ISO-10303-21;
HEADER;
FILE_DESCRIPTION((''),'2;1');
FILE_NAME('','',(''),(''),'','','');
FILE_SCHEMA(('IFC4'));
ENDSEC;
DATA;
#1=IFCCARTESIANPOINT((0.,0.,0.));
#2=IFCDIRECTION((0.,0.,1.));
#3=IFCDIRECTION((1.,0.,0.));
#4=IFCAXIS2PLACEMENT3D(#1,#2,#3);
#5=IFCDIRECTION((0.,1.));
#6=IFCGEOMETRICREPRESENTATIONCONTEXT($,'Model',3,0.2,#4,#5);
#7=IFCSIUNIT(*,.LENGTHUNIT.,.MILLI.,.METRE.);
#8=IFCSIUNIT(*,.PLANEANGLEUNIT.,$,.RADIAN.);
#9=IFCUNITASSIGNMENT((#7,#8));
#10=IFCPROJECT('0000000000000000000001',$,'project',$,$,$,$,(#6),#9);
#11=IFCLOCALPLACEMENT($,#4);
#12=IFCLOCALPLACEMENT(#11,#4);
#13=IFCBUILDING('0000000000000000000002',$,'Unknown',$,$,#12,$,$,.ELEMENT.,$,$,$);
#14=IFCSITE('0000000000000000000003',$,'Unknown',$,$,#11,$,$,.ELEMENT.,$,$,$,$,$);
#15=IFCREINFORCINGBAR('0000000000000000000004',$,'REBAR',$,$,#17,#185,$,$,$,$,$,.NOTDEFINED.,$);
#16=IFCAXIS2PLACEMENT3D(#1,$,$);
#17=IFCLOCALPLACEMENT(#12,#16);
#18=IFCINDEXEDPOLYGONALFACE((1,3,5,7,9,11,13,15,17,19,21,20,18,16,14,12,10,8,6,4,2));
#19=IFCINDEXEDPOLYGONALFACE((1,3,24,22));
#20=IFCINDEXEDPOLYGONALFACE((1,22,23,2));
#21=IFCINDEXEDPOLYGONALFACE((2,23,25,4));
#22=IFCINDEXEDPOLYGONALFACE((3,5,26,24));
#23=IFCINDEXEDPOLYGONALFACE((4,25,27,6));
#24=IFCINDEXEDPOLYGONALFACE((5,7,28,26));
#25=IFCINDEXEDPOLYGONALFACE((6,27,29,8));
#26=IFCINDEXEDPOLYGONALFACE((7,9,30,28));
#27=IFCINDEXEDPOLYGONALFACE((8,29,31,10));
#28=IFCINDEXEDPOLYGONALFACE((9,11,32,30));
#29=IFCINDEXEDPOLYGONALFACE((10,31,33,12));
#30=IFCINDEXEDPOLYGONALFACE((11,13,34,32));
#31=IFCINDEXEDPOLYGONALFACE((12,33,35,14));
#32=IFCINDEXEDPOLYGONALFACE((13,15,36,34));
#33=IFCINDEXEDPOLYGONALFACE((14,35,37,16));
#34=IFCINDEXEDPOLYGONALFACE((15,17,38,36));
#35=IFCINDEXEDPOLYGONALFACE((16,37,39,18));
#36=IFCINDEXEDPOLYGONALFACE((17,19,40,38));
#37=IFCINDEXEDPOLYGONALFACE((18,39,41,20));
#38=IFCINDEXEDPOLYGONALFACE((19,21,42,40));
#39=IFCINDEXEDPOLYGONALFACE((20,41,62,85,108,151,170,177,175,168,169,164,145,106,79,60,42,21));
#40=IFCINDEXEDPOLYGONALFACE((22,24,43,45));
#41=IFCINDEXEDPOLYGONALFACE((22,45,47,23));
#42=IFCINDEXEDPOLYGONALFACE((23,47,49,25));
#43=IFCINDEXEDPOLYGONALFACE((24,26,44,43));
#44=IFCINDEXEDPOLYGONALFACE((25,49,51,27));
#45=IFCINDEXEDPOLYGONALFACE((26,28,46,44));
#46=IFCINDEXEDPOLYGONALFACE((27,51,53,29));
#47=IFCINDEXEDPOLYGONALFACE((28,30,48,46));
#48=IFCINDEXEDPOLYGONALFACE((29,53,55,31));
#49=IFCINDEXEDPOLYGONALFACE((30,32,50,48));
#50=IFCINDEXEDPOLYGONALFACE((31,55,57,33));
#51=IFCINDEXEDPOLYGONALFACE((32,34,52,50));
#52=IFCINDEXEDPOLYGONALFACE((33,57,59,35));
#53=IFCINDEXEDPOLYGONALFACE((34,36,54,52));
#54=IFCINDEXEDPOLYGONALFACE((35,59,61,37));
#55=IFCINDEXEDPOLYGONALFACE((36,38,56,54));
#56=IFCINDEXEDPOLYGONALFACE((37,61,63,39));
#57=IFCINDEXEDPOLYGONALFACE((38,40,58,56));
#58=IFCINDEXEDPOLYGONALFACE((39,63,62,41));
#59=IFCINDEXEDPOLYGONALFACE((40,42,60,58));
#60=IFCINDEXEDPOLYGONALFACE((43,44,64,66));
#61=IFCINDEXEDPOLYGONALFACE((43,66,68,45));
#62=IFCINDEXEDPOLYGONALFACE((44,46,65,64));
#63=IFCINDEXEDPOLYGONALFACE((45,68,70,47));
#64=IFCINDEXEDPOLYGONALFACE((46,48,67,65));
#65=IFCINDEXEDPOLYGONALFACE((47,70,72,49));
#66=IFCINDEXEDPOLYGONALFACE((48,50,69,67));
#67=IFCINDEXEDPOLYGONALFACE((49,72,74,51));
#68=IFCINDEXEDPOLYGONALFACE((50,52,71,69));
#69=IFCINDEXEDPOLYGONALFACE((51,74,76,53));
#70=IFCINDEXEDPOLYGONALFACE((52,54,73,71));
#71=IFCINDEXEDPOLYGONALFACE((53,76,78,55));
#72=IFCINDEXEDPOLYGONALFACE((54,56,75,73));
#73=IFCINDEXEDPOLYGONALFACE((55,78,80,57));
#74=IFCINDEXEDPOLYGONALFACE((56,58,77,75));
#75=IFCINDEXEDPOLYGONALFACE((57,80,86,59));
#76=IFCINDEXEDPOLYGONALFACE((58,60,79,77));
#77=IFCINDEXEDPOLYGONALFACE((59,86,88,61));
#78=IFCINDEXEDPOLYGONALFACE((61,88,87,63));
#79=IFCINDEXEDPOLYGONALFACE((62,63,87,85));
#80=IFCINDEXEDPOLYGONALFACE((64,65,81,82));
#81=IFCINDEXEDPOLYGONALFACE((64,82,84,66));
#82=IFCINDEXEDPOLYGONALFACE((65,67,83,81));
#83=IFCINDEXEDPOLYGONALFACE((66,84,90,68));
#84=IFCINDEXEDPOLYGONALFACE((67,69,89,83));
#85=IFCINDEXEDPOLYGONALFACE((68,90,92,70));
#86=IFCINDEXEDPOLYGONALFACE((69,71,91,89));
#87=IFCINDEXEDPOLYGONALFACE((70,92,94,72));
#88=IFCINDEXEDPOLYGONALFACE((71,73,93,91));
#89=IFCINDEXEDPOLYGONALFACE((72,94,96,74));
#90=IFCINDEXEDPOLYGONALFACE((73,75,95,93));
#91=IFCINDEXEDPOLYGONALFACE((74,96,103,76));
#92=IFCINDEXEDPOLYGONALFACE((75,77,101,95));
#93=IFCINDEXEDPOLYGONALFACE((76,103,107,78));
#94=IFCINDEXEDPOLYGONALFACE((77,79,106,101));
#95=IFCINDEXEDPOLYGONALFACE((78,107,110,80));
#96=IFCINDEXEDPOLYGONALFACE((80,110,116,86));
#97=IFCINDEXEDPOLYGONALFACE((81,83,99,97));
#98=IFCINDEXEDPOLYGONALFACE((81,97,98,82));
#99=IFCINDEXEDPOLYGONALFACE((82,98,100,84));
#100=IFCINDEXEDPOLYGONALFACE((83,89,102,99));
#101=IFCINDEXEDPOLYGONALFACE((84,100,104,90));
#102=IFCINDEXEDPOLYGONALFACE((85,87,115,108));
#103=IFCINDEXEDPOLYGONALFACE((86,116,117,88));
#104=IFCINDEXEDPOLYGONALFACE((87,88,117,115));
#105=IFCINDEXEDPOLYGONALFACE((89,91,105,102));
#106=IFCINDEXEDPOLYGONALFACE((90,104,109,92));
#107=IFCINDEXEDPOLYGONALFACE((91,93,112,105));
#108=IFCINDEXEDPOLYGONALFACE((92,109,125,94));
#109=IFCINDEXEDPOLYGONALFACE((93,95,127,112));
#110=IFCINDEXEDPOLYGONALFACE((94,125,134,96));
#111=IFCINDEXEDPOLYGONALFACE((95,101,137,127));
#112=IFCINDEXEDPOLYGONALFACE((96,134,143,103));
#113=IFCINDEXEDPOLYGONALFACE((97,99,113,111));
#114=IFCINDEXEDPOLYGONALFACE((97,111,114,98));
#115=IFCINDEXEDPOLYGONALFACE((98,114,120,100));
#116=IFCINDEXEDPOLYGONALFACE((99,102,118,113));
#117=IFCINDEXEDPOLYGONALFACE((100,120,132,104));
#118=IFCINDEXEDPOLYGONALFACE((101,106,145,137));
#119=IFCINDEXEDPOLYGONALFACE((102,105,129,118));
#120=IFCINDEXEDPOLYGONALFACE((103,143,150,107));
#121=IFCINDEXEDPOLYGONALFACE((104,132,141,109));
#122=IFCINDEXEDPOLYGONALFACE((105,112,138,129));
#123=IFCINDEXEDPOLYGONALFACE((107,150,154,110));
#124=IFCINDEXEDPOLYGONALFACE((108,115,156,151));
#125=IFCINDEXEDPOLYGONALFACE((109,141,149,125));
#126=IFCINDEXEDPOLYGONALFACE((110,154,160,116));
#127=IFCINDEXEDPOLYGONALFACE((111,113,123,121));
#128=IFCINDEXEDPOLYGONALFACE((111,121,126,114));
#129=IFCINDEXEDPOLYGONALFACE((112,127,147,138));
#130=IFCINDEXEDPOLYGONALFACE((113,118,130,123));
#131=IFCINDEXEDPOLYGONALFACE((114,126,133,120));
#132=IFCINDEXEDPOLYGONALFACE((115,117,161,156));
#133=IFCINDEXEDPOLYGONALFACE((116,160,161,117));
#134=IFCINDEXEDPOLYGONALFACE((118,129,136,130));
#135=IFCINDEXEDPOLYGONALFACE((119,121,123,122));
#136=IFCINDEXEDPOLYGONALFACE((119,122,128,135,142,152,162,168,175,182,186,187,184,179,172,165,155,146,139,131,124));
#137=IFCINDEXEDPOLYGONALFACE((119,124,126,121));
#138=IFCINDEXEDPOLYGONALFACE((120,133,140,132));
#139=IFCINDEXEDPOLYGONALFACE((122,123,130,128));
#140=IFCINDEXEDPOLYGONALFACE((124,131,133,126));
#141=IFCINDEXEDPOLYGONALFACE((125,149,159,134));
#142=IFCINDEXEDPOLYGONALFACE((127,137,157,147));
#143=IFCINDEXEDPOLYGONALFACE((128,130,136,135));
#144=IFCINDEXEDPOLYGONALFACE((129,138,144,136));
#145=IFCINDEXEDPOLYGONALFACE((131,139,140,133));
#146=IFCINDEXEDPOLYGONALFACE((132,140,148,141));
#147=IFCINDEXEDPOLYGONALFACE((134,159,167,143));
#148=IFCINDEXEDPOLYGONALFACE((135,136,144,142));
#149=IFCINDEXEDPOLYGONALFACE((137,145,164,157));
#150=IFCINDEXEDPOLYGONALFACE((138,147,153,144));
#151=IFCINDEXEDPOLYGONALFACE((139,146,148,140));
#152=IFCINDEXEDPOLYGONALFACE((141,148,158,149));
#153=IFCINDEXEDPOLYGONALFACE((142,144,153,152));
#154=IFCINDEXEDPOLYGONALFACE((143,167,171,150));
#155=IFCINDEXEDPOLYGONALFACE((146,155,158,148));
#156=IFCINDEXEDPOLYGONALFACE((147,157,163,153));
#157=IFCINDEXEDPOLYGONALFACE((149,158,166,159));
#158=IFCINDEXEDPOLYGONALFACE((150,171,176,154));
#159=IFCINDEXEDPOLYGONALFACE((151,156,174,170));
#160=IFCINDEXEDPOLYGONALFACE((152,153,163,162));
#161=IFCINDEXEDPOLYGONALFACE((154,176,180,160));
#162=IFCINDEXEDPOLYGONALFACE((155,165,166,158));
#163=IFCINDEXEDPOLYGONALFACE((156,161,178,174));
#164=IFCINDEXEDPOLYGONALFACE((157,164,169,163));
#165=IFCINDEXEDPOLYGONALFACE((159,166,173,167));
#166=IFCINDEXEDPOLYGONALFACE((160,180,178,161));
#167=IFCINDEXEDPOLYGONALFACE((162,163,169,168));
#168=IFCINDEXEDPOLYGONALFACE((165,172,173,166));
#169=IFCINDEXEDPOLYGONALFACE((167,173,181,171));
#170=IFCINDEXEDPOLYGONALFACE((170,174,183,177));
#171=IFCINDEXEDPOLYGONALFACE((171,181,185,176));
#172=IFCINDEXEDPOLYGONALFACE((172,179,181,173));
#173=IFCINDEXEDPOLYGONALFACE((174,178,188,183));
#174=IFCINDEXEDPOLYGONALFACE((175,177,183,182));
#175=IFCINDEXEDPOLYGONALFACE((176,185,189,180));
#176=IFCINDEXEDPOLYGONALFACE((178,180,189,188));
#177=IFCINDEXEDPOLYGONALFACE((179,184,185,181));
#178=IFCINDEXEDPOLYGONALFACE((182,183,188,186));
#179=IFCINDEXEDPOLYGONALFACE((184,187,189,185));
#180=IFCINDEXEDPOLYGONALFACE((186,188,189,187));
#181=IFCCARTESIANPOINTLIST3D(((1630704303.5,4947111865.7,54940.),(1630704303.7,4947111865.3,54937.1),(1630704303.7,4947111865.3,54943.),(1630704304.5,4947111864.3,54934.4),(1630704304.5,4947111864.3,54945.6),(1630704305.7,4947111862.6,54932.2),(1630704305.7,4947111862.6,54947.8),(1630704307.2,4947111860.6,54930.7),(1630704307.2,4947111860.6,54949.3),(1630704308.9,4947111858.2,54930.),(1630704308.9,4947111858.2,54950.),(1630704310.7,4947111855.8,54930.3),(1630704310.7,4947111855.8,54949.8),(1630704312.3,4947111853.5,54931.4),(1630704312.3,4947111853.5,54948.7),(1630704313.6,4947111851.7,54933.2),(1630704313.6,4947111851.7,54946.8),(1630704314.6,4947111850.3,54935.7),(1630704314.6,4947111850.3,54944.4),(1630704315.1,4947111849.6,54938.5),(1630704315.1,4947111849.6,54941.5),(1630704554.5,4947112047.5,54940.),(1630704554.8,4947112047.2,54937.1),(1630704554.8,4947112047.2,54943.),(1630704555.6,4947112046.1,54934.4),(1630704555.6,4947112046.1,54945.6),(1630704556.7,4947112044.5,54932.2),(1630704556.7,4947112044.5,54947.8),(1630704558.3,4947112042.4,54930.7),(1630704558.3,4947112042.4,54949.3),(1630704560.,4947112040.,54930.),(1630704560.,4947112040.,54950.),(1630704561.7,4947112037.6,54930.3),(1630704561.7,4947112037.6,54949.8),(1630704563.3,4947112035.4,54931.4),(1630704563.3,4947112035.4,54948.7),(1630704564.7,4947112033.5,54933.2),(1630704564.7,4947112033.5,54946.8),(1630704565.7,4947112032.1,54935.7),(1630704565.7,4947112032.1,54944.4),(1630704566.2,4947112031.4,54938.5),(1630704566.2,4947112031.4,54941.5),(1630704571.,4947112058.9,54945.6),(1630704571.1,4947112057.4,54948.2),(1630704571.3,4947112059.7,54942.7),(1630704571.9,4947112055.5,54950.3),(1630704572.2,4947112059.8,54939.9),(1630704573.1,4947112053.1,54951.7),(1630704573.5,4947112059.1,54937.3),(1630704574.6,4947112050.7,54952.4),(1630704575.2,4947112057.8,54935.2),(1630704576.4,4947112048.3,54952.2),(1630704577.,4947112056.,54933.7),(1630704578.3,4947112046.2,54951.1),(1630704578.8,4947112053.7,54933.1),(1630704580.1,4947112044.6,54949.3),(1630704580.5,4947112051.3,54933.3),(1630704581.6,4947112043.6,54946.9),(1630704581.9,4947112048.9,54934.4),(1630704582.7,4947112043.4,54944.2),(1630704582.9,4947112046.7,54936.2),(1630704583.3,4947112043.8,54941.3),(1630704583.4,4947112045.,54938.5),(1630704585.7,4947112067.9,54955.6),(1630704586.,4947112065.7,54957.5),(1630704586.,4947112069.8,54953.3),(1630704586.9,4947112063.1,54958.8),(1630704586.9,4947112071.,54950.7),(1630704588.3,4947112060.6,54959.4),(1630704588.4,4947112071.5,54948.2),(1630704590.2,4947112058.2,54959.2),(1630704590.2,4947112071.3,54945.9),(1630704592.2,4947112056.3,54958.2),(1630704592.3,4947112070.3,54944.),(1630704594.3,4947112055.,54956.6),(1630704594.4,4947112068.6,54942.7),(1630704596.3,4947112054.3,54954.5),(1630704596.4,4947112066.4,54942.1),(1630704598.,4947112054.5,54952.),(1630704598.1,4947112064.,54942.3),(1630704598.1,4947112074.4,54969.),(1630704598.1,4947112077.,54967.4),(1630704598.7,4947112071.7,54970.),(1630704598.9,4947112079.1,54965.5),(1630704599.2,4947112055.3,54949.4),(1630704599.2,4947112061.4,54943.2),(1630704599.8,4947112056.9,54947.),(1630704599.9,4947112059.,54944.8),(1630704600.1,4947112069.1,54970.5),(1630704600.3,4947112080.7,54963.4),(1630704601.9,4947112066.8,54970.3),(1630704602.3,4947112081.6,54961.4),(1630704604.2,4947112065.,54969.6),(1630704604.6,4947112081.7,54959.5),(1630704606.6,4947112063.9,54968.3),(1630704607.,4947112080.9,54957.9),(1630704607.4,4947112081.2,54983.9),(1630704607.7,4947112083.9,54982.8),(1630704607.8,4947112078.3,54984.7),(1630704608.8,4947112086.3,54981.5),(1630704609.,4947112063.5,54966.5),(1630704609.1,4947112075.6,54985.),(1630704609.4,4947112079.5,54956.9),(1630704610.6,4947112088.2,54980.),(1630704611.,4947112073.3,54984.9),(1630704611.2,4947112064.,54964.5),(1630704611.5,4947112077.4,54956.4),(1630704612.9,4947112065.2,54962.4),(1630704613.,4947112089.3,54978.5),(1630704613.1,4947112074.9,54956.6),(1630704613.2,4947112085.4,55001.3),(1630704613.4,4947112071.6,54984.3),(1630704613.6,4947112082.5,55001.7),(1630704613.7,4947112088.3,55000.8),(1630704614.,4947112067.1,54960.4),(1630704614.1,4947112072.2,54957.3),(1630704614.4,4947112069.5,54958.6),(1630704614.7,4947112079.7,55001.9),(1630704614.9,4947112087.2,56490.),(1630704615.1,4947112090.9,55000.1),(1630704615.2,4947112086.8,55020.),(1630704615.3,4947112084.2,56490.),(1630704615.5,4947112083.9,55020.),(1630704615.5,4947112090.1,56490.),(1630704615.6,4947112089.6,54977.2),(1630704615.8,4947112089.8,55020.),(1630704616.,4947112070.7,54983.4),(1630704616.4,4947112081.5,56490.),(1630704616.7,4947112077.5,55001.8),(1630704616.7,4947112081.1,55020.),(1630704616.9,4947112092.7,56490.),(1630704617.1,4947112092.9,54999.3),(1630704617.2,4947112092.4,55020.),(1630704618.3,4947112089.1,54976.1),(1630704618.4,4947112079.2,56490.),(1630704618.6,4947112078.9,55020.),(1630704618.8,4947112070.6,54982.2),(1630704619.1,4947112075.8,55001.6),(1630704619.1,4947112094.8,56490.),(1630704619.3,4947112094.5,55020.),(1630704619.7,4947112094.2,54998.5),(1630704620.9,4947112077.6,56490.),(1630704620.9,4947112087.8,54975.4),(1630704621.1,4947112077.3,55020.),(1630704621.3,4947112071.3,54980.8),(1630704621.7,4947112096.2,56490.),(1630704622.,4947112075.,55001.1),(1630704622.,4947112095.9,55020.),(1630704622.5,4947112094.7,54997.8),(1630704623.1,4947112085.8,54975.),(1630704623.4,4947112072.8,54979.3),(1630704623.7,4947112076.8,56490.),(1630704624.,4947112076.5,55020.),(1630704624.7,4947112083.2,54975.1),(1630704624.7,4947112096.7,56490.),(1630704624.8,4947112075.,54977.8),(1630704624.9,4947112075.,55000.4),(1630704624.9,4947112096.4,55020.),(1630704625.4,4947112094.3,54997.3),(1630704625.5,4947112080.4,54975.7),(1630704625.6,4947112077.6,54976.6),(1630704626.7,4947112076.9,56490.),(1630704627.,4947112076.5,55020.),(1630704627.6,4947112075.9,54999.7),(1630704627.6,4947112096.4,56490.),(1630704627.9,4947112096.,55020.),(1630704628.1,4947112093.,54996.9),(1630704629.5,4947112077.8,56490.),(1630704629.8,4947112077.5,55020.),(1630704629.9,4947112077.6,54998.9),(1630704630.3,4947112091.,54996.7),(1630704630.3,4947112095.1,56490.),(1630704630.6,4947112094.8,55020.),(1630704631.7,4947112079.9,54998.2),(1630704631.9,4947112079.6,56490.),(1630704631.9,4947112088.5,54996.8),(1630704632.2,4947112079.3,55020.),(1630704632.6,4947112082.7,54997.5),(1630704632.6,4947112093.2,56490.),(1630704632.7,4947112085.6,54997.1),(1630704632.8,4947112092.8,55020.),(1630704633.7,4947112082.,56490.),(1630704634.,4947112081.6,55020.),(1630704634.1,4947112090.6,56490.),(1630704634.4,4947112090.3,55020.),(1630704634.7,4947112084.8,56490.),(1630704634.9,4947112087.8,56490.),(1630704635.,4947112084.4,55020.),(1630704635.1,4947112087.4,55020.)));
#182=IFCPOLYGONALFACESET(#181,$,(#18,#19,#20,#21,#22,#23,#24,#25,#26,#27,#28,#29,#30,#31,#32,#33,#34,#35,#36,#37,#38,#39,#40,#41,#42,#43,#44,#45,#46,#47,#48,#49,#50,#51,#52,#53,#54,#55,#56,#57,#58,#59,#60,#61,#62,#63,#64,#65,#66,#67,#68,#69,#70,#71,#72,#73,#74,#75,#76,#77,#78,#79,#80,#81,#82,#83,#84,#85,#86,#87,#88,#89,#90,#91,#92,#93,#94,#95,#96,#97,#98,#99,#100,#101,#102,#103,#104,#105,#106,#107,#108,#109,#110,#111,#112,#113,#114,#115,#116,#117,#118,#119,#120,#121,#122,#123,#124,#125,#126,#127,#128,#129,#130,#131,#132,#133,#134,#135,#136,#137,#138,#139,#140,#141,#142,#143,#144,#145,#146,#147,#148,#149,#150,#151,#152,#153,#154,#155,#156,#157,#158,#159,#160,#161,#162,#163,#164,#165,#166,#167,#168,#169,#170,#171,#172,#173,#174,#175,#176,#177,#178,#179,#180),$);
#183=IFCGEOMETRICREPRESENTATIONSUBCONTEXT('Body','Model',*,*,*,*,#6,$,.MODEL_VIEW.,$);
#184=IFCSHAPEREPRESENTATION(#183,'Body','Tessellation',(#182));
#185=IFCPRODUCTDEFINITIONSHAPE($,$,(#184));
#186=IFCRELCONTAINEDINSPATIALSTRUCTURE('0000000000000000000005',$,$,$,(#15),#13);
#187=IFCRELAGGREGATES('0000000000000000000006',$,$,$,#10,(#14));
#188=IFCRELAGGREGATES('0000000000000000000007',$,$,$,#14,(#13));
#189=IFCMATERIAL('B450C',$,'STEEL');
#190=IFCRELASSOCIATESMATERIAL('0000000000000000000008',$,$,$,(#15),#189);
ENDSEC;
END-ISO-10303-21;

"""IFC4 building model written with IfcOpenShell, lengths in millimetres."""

from ifc_helpers import new_model, entity, si_unit, direction, frame, origin_with_axes, place, context, subcontext, project, spatial, material, element, save


model = new_model("IFC4")

# Units and contexts
model_context = context("Model", 3, precision=0.2, world=origin_with_axes(), true_north=direction((0.0, 1.0)))
body_context = subcontext(model_context, "Body", "Model", "MODEL_VIEW")
ifc_project = project(units=[si_unit("LENGTHUNIT", "METRE", prefix="MILLI"), si_unit("PLANEANGLEUNIT", "RADIAN")], contexts=[model_context])

# Site, building
site_placement = place(None, origin_with_axes())
site = spatial("IfcSite", under=ifc_project, at=site_placement, Name="Unknown", CompositionType="ELEMENT")
building_placement = place(site_placement, origin_with_axes())
building = spatial("IfcBuilding", under=site, at=building_placement, Name="Unknown", CompositionType="ELEMENT")

# Reinforcing bar
ifc_material = material(Name="B450C", Category="STEEL")
reinforcing_bar_1_placement = place(building_placement, frame((1630704636.4, 4947112156.2, 54890.0), z_axis=(0.586613, -0.809868, 0.0), x_axis=(0.0, 0.0, 1.0)))
element("IfcReinforcingBar", 1, at=reinforcing_bar_1_placement, inside=building, material=ifc_material, Name="REBAR", PredefinedType="NOTDEFINED", context=body_context, shape_type="AdvancedSweptSolid", body=[
    entity("IfcSweptDiskSolid", entity("IfcIndexedPolyCurve", entity("IfcCartesianPointList3D", [[50.0, 440.0, 50.0], [50.0, 130.0, 50.0], [73.4, 73.4, 50.0], [130.0, 50.0, 50.0], [1600.0, 50.0, 49.5]]), [entity("IfcLineIndex", [1, 2]), entity("IfcArcIndex", [2, 3, 4]), entity("IfcLineIndex", [4, 5])]), 10.0),
])

save(model, "model.ifc")
